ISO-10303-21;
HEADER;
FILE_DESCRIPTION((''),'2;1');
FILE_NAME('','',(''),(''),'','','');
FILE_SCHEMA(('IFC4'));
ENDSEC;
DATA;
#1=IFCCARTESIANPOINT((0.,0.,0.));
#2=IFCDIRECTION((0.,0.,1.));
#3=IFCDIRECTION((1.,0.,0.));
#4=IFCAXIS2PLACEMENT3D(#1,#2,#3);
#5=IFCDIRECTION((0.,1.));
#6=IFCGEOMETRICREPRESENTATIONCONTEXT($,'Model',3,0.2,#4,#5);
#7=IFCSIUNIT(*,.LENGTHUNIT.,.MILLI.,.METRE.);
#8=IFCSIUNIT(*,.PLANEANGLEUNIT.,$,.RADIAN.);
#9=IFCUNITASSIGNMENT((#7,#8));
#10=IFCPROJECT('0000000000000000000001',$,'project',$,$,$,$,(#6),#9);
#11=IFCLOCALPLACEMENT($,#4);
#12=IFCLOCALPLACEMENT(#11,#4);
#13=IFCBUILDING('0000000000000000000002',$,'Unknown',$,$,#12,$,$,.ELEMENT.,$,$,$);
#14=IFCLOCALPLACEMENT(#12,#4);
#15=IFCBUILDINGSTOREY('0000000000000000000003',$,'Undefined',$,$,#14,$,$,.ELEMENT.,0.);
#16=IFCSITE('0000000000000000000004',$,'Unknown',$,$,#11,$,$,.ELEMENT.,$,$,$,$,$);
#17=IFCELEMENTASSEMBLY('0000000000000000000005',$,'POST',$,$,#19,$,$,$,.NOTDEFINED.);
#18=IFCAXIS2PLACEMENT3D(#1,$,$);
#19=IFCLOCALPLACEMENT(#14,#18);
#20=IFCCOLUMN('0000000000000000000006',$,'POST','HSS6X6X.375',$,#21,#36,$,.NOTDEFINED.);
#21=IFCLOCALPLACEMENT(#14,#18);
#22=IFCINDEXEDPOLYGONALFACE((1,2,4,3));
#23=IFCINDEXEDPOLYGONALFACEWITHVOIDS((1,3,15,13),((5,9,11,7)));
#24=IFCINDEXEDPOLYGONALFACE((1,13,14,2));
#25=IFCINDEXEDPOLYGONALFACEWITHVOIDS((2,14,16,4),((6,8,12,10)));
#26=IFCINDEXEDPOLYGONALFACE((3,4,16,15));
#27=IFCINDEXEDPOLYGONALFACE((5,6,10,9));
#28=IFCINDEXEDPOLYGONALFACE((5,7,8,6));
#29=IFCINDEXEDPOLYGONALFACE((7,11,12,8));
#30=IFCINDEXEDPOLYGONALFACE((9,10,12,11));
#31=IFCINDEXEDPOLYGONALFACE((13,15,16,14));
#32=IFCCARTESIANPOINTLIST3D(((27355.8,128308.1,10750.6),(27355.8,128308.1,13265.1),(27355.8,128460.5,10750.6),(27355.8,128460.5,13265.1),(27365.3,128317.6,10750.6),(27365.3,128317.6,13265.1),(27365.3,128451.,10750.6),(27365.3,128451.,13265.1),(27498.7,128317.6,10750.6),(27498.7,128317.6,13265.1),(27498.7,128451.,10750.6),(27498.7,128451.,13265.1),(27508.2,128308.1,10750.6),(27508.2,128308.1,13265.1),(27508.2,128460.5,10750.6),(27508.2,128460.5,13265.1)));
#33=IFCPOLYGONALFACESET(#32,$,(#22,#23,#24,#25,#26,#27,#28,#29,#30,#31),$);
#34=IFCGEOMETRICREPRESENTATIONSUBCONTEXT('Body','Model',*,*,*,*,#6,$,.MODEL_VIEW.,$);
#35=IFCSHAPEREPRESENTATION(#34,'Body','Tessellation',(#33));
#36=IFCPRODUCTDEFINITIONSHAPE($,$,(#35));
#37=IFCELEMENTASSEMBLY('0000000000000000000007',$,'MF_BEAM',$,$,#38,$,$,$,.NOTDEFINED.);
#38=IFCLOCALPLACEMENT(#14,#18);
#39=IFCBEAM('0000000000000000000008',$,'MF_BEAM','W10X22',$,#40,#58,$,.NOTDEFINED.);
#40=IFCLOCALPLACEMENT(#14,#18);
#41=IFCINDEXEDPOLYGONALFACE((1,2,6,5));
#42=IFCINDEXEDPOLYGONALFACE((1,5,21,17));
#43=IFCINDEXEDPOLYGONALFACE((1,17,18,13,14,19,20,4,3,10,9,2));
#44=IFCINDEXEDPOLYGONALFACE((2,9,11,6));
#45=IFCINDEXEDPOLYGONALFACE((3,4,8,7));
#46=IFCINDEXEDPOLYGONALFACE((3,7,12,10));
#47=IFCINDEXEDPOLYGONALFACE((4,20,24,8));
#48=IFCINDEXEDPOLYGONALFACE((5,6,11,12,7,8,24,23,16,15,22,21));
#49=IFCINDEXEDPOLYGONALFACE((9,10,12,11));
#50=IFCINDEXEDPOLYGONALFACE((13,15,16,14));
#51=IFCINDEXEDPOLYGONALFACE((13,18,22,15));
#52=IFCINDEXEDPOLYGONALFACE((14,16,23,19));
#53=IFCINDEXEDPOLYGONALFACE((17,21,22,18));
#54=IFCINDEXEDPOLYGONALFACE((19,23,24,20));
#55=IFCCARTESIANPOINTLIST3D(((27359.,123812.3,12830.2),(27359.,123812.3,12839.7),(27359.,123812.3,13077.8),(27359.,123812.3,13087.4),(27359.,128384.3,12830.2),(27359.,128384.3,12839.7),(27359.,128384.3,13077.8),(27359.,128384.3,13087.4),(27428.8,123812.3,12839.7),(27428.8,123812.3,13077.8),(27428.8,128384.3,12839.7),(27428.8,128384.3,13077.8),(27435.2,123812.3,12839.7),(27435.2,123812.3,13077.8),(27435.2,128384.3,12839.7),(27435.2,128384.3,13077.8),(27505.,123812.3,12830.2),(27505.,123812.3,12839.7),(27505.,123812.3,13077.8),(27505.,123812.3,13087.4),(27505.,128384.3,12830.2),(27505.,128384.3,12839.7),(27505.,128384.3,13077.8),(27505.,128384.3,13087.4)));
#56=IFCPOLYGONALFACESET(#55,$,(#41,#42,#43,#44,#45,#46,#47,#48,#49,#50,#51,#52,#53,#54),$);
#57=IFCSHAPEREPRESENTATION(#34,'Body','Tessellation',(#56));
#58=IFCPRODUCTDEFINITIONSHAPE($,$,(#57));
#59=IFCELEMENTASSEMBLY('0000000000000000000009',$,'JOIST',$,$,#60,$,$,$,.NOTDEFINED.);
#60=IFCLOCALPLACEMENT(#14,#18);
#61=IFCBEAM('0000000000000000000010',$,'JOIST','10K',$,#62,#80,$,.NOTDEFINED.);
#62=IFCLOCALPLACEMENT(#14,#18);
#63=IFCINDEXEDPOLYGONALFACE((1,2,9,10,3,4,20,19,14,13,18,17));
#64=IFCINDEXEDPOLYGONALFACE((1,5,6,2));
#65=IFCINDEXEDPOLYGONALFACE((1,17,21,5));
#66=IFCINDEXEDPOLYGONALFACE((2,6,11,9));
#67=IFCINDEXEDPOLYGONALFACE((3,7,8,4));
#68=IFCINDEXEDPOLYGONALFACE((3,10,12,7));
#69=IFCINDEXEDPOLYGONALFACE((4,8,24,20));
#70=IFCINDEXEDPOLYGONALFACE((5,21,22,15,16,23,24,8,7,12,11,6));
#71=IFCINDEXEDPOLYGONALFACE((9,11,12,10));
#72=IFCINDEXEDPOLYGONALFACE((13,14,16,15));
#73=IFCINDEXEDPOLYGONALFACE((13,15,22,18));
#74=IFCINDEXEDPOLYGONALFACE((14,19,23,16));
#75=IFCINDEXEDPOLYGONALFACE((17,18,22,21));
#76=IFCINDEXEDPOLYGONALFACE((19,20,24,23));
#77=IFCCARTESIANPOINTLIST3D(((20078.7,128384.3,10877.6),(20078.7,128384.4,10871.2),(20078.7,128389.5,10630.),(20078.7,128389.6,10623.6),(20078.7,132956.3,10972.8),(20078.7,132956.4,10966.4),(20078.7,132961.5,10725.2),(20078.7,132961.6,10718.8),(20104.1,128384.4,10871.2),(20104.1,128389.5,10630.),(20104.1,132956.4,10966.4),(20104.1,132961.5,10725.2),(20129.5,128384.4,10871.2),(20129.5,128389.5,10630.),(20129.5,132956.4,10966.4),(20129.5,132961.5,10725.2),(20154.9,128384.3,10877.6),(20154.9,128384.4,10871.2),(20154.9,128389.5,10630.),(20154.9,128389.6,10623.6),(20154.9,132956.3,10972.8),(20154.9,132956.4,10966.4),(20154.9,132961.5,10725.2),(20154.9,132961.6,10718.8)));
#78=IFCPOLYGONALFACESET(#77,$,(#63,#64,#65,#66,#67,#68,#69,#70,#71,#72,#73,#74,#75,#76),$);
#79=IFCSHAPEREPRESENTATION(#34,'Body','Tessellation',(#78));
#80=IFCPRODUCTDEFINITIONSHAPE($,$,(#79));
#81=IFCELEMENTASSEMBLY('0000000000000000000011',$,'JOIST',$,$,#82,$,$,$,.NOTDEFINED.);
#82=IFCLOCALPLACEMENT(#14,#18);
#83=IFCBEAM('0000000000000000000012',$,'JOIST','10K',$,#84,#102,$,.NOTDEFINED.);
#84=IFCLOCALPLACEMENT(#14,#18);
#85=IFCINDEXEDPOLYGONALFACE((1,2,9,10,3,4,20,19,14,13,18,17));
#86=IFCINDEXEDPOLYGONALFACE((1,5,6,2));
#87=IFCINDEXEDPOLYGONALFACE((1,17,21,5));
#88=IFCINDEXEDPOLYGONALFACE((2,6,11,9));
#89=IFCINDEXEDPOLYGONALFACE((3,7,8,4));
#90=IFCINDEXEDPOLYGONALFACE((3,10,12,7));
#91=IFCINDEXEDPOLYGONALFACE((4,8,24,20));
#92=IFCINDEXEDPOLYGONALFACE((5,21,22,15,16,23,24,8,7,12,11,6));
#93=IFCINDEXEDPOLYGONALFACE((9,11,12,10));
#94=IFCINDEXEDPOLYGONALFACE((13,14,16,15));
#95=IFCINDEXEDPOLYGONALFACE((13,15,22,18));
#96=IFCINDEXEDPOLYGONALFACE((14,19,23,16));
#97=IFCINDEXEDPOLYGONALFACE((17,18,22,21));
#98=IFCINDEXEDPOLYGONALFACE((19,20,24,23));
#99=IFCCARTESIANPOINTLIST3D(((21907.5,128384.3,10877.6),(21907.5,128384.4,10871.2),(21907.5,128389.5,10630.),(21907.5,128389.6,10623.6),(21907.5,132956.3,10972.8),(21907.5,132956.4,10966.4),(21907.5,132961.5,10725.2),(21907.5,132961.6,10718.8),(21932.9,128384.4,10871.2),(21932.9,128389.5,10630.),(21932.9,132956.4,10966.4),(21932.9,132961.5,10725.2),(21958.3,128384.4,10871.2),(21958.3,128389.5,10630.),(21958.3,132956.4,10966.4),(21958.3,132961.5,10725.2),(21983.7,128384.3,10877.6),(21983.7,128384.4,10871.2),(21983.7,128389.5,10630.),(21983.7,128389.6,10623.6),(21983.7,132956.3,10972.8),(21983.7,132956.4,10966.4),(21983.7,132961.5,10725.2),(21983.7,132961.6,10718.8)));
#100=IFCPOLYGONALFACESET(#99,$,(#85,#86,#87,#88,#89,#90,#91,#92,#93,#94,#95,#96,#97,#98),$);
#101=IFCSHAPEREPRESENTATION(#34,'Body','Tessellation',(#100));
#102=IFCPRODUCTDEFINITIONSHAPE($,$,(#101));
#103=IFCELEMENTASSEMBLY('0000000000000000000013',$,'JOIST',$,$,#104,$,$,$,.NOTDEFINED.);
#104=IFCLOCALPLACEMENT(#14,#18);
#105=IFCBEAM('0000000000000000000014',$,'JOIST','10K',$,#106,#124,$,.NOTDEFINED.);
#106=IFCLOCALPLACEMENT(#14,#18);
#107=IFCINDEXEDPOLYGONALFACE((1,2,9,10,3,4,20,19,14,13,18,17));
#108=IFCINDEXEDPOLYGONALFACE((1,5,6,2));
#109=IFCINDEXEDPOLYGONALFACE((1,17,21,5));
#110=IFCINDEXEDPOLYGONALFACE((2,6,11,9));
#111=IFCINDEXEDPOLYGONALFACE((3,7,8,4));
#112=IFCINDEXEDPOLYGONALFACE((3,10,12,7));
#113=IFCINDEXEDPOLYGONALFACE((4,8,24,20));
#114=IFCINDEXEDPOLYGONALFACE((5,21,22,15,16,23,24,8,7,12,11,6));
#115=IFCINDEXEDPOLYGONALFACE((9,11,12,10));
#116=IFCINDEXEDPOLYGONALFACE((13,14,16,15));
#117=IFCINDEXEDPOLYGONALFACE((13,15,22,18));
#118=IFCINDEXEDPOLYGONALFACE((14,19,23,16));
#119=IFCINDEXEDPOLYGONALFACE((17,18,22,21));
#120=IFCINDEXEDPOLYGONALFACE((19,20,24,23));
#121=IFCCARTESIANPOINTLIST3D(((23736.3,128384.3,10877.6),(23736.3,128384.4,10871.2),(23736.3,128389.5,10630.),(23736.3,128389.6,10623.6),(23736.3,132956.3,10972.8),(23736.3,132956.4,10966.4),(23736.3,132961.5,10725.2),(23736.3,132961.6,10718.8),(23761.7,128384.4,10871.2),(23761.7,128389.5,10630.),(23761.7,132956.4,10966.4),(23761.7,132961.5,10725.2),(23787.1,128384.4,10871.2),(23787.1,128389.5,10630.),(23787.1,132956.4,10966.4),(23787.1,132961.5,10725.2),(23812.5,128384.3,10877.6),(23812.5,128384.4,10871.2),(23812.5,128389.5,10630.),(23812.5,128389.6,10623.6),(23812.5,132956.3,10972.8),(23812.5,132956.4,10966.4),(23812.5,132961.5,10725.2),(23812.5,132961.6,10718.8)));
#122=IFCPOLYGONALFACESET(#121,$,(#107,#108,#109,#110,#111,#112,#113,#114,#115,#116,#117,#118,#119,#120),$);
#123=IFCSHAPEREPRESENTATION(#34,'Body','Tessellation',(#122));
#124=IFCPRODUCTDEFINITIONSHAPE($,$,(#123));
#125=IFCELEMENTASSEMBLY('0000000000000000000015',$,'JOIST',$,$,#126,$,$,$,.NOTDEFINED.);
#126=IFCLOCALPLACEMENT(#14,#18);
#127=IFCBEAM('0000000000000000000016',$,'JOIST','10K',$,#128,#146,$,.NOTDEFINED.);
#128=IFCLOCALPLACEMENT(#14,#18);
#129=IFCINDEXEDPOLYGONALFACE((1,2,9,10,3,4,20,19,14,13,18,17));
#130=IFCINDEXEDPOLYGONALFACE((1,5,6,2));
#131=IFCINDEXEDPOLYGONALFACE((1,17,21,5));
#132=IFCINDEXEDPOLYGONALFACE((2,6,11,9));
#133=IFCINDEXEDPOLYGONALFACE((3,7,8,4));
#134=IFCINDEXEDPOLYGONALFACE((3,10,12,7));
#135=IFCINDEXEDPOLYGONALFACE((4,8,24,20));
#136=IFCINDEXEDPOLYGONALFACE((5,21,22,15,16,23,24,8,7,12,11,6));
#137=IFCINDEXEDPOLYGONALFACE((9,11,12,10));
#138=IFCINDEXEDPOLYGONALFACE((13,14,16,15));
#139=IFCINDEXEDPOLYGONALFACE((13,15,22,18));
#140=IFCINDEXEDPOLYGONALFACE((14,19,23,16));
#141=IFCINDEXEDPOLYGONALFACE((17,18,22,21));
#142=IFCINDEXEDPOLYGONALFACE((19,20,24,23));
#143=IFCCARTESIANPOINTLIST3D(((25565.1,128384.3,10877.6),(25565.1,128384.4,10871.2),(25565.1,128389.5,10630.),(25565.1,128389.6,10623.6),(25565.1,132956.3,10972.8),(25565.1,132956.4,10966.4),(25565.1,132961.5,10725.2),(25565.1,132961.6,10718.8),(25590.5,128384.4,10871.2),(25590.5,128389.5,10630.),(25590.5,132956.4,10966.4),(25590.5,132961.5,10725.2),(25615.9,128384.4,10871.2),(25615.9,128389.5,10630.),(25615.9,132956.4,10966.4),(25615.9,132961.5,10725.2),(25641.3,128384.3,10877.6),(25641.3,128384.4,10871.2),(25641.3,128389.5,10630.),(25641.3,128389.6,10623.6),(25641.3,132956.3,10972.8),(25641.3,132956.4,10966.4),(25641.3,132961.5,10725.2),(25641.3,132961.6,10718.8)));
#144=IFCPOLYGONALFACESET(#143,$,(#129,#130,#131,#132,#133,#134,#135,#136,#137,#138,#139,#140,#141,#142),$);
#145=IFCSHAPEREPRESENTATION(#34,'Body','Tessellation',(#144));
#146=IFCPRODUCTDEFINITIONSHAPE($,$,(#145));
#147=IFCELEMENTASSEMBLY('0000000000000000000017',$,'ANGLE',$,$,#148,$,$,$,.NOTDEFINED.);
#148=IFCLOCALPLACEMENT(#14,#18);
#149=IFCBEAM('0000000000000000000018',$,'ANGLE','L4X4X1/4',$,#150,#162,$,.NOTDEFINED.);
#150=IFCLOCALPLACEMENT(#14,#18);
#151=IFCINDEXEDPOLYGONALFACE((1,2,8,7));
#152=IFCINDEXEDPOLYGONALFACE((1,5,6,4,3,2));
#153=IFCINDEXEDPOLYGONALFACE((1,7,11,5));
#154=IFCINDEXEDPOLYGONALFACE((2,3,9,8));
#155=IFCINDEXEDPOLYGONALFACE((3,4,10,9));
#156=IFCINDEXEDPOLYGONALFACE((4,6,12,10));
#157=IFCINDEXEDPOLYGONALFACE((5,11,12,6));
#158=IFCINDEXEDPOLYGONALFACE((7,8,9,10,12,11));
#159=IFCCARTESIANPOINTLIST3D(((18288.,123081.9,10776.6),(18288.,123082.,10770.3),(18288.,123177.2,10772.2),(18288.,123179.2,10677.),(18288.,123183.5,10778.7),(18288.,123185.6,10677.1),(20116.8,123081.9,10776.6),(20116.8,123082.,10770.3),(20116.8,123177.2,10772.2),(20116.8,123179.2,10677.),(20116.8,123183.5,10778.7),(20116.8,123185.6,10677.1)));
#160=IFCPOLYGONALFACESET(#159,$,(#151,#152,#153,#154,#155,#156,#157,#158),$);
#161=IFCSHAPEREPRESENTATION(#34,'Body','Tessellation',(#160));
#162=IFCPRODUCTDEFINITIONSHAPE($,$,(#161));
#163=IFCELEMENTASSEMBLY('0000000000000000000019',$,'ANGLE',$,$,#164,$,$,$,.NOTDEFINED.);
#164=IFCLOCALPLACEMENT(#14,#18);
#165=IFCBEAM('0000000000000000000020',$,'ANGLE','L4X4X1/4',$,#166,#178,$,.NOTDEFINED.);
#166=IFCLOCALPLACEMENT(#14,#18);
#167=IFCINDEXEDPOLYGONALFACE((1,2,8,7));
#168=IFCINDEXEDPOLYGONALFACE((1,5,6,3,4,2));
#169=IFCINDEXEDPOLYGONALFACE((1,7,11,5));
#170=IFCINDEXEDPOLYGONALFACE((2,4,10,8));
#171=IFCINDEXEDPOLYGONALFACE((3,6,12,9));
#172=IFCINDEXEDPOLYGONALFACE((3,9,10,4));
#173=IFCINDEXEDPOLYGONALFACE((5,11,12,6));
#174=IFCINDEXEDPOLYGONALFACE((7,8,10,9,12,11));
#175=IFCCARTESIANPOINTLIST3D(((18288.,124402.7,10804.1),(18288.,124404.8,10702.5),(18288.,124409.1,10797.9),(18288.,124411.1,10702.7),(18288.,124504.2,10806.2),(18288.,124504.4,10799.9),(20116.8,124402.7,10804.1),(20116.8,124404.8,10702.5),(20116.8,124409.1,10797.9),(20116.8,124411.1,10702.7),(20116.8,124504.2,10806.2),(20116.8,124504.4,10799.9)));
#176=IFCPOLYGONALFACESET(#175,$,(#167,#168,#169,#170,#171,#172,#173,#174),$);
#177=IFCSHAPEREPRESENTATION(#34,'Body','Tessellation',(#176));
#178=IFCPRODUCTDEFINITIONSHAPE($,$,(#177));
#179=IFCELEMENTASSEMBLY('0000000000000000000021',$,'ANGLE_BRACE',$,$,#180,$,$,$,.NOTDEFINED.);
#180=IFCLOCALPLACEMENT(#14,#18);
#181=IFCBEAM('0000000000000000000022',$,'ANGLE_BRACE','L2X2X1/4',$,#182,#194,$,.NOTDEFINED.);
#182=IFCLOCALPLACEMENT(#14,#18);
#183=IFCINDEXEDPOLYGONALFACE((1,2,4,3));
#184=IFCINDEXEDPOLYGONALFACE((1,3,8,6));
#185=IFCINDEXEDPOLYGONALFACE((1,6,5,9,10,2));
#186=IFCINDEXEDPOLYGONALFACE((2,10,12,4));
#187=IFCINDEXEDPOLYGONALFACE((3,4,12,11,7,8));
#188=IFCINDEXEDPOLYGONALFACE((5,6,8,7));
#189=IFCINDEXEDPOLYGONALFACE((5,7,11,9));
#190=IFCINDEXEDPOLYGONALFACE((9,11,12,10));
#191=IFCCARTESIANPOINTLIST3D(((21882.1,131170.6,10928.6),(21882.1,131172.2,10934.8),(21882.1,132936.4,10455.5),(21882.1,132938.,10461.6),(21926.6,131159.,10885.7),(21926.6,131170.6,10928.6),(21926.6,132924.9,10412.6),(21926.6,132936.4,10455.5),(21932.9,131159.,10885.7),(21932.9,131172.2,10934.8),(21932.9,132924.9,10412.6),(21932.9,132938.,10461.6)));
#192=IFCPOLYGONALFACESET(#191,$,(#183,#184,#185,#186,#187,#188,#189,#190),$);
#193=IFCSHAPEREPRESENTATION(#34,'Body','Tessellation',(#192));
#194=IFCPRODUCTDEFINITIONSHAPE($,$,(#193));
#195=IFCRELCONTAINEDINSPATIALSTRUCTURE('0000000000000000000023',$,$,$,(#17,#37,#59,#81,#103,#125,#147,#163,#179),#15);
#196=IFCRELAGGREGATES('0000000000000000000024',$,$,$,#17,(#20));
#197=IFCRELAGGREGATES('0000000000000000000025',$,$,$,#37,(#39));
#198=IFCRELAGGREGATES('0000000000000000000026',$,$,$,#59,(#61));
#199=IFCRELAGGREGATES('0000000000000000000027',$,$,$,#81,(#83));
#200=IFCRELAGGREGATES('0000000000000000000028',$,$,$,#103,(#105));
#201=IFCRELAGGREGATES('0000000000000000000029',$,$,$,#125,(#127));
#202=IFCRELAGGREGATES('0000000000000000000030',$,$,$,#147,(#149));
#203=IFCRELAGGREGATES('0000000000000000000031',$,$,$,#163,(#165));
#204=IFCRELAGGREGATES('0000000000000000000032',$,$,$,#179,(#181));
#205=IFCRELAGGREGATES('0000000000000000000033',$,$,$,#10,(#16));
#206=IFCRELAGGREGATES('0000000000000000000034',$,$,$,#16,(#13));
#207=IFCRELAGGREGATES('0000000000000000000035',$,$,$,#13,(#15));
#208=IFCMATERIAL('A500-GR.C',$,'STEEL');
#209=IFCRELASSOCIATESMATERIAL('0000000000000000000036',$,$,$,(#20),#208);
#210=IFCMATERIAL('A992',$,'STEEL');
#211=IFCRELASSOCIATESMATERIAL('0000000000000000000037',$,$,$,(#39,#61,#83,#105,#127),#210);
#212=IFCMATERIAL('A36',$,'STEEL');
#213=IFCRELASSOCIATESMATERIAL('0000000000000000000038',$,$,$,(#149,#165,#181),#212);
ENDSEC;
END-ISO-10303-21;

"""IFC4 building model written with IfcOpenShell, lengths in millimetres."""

from ifc_helpers import new_model, si_unit, direction, frame, origin_with_axes, place, context, subcontext, project, spatial, line, indexed_curve, outline, extrude, material, element, aggregate, save


model = new_model("IFC4")

# Units and contexts
model_context = context("Model", 3, precision=0.2, world=origin_with_axes(), true_north=direction((0.0, 1.0)))
body_context = subcontext(model_context, "Body", "Model", "MODEL_VIEW")
ifc_project = project(units=[si_unit("LENGTHUNIT", "METRE", prefix="MILLI"), si_unit("PLANEANGLEUNIT", "RADIAN")], contexts=[model_context])

# Site, building, storey
site_placement = place(None, origin_with_axes())
site = spatial("IfcSite", under=ifc_project, at=site_placement, Name="Unknown", CompositionType="ELEMENT")
building_placement = place(site_placement, origin_with_axes())
building = spatial("IfcBuilding", under=site, at=building_placement, Name="Unknown", CompositionType="ELEMENT")
storey_placement = place(building_placement, origin_with_axes())
storey = spatial("IfcBuildingStorey", under=building, at=storey_placement, Name="Undefined", CompositionType="ELEMENT", Elevation=0.0)

# Element assembly, column
assembly_1_placement = place(storey_placement, frame((27432.0, 128384.3, 10750.5), z_axis=(0.0, -1.0, 0.0), x_axis=(0.0, 0.0, 1.0)))
assembly_1 = element("IfcElementAssembly", 1, at=assembly_1_placement, inside=storey, Name="POST", PredefinedType="NOTDEFINED")
ifc_material_1 = material(Name="A500-GR.C", Category="STEEL")
column_placement = place(assembly_1_placement, origin_with_axes())
column = element("IfcColumn", 2, at=column_placement, material=ifc_material_1, Name="POST", Description="HSS6X6X.375", PredefinedType="NOTDEFINED", context=body_context, shape_type="SolidModel", body=[
    extrude(outline(indexed_curve([(-76.2, -76.2), (76.2, -76.2), (76.2, 76.2), (-76.2, 76.2)], segments=[line(1, 2, 3, 4, 1)]), holes=[indexed_curve([(-66.7, -66.7), (-66.7, 66.7), (66.7, 66.7), (66.7, -66.7)], segments=[line(1, 2, 3, 4, 1)])]), frame((0.0, 0.0, 0.0), z_axis=(-1.0, 0.0, 0.0), x_axis=(0.0, 0.0, 1.0)), (0.0, 0.0, -1.0), 2514.6),
])
aggregate(assembly_1, [column])

# Element assemblies, beams
assembly_2_placement = place(storey_placement, frame((27432.0, 123812.3, 12958.8), z_axis=(1.0, 0.0, 0.0), x_axis=(0.0, 1.0, 0.0)))
assembly_2 = element("IfcElementAssembly", 3, at=assembly_2_placement, inside=storey, Name="MF_BEAM", PredefinedType="NOTDEFINED")
ifc_material_2 = material(Name="A992", Category="STEEL")
beam_1_placement = place(assembly_2_placement, origin_with_axes())
beam_1 = element("IfcBeam", 4, at=beam_1_placement, material=ifc_material_2, Name="MF_BEAM", Description="W10X22", PredefinedType="NOTDEFINED", context=body_context, shape_type="SolidModel", body=[
    extrude(outline(indexed_curve([(-73.0, -128.6), (73.0, -128.6), (73.0, -119.1), (3.2, -119.1), (3.2, 119.1), (73.0, 119.1), (73.0, 128.6), (-73.0, 128.6), (-73.0, 119.1), (-3.2, 119.1), (-3.2, -119.1), (-73.0, -119.1)], segments=[line(1, 2, 3, 4, 5, 6, 7, 8, 9, 10, 11, 12, 1)])), frame((0.0, 0.0, 0.0), z_axis=(-1.0, 0.0, 0.0), x_axis=(0.0, 0.0, 1.0)), (0.0, 0.0, -1.0), 4572.0),
])
aggregate(assembly_2, [beam_1])
assembly_3_placement = place(storey_placement, frame((20116.8, 128386.9, 10750.6), z_axis=(1.0, 0.0, 0.0), x_axis=(0.0, 0.999783, 0.020819)))
assembly_3 = element("IfcElementAssembly", 5, at=assembly_3_placement, inside=storey, Name="JOIST", PredefinedType="NOTDEFINED")
beam_2_placement = place(assembly_3_placement, origin_with_axes())
beam_2 = element("IfcBeam", 6, at=beam_2_placement, material=ifc_material_2, Name="JOIST", Description="10K", PredefinedType="NOTDEFINED", context=body_context, shape_type="SolidModel", body=[
    extrude(outline(indexed_curve([(-38.1, -127.0), (38.1, -127.0), (38.1, -120.7), (12.7, -120.7), (12.7, 120.7), (38.1, 120.7), (38.1, 127.0), (-38.1, 127.0), (-38.1, 120.7), (-12.7, 120.7), (-12.7, -120.7), (-38.1, -120.7)], segments=[line(1, 2, 3, 4, 5, 6, 7, 8, 9, 10, 11, 12, 1)])), frame((0.0, 0.0, 0.0), z_axis=(-1.0, 0.0, 0.0), x_axis=(0.0, 0.0, 1.0)), (0.0, 0.0, -1.0), 4573.0),
])
aggregate(assembly_3, [beam_2])
assembly_4_placement = place(storey_placement, frame((21945.6, 128386.9, 10750.6), z_axis=(1.0, 0.0, 0.0), x_axis=(0.0, 0.999783, 0.020819)))
assembly_4 = element("IfcElementAssembly", 7, at=assembly_4_placement, inside=storey, Name="JOIST", PredefinedType="NOTDEFINED")
beam_3_placement = place(assembly_4_placement, origin_with_axes())
beam_3 = element("IfcBeam", 8, at=beam_3_placement, material=ifc_material_2, Name="JOIST", Description="10K", PredefinedType="NOTDEFINED", context=body_context, shape_type="SolidModel", body=[
    extrude(outline(indexed_curve([(-38.1, -127.0), (38.1, -127.0), (38.1, -120.7), (12.7, -120.7), (12.7, 120.7), (38.1, 120.7), (38.1, 127.0), (-38.1, 127.0), (-38.1, 120.7), (-12.7, 120.7), (-12.7, -120.7), (-38.1, -120.7)], segments=[line(1, 2, 3, 4, 5, 6, 7, 8, 9, 10, 11, 12, 1)])), frame((0.0, 0.0, 0.0), z_axis=(-1.0, 0.0, 0.0), x_axis=(0.0, 0.0, 1.0)), (0.0, 0.0, -1.0), 4573.0),
])
aggregate(assembly_4, [beam_3])
assembly_5_placement = place(storey_placement, frame((23774.4, 128386.9, 10750.6), z_axis=(1.0, 0.0, 0.0), x_axis=(0.0, 0.999783, 0.020819)))
assembly_5 = element("IfcElementAssembly", 9, at=assembly_5_placement, inside=storey, Name="JOIST", PredefinedType="NOTDEFINED")
beam_4_placement = place(assembly_5_placement, origin_with_axes())
beam_4 = element("IfcBeam", 10, at=beam_4_placement, material=ifc_material_2, Name="JOIST", Description="10K", PredefinedType="NOTDEFINED", context=body_context, shape_type="SolidModel", body=[
    extrude(outline(indexed_curve([(-38.1, -127.0), (38.1, -127.0), (38.1, -120.7), (12.7, -120.7), (12.7, 120.7), (38.1, 120.7), (38.1, 127.0), (-38.1, 127.0), (-38.1, 120.7), (-12.7, 120.7), (-12.7, -120.7), (-38.1, -120.7)], segments=[line(1, 2, 3, 4, 5, 6, 7, 8, 9, 10, 11, 12, 1)])), frame((0.0, 0.0, 0.0), z_axis=(-1.0, 0.0, 0.0), x_axis=(0.0, 0.0, 1.0)), (0.0, 0.0, -1.0), 4573.0),
])
aggregate(assembly_5, [beam_4])
assembly_6_placement = place(storey_placement, frame((25603.2, 128386.9, 10750.6), z_axis=(1.0, 0.0, 0.0), x_axis=(0.0, 0.999783, 0.020819)))
assembly_6 = element("IfcElementAssembly", 11, at=assembly_6_placement, inside=storey, Name="JOIST", PredefinedType="NOTDEFINED")
beam_5_placement = place(assembly_6_placement, origin_with_axes())
beam_5 = element("IfcBeam", 12, at=beam_5_placement, material=ifc_material_2, Name="JOIST", Description="10K", PredefinedType="NOTDEFINED", context=body_context, shape_type="SolidModel", body=[
    extrude(outline(indexed_curve([(-38.1, -127.0), (38.1, -127.0), (38.1, -120.7), (12.7, -120.7), (12.7, 120.7), (38.1, 120.7), (38.1, 127.0), (-38.1, 127.0), (-38.1, 120.7), (-12.7, 120.7), (-12.7, -120.7), (-38.1, -120.7)], segments=[line(1, 2, 3, 4, 5, 6, 7, 8, 9, 10, 11, 12, 1)])), frame((0.0, 0.0, 0.0), z_axis=(-1.0, 0.0, 0.0), x_axis=(0.0, 0.0, 1.0)), (0.0, 0.0, -1.0), 4573.0),
])
aggregate(assembly_6, [beam_5])
assembly_7_placement = place(storey_placement, frame((18288.0, 123133.7, 10726.9), z_axis=(0.0, 0.020829, -0.999783), x_axis=(1.0, 0.0, 0.0)))
assembly_7 = element("IfcElementAssembly", 13, at=assembly_7_placement, inside=storey, Name="ANGLE", PredefinedType="NOTDEFINED")
ifc_material_3 = material(Name="A36", Category="STEEL")
beam_6_placement = place(assembly_7_placement, origin_with_axes())
beam_6 = element("IfcBeam", 14, at=beam_6_placement, material=ifc_material_3, Name="ANGLE", Description="L4X4X1/4", PredefinedType="NOTDEFINED", context=body_context, shape_type="SolidModel", body=[
    extrude(outline(indexed_curve([(-50.8, -50.8), (50.8, -50.8), (50.8, -44.5), (-44.5, -44.5), (-44.5, 50.8), (-50.8, 50.8)], segments=[line(1, 2, 3, 4, 5, 6, 1)])), frame((0.0, 0.0, 0.0), z_axis=(-1.0, 0.0, 0.0), x_axis=(0.0, 0.0, 1.0)), (0.0, 0.0, -1.0), 1828.8),
])
aggregate(assembly_7, [beam_6])
assembly_8_placement = place(storey_placement, frame((18288.0, 124454.5, 10754.4), z_axis=(0.0, 0.999783, 0.020819), x_axis=(1.0, 0.0, 0.0)))
assembly_8 = element("IfcElementAssembly", 15, at=assembly_8_placement, inside=storey, Name="ANGLE", PredefinedType="NOTDEFINED")
beam_7_placement = place(assembly_8_placement, origin_with_axes())
beam_7 = element("IfcBeam", 16, at=beam_7_placement, material=ifc_material_3, Name="ANGLE", Description="L4X4X1/4", PredefinedType="NOTDEFINED", context=body_context, shape_type="SolidModel", body=[
    extrude(outline(indexed_curve([(-50.8, -50.8), (50.8, -50.8), (50.8, -44.5), (-44.5, -44.5), (-44.5, 50.8), (-50.8, 50.8)], segments=[line(1, 2, 3, 4, 5, 6, 1)])), frame((0.0, 0.0, 0.0), z_axis=(-1.0, 0.0, 0.0), x_axis=(0.0, 0.0, 1.0)), (0.0, 0.0, -1.0), 1828.8),
])
aggregate(assembly_8, [beam_7])
assembly_9_placement = place(storey_placement, frame((21907.5, 131165.6, 10910.2), z_axis=(-1.0, 0.0, 0.0), x_axis=(0.0, 0.965926, -0.258819)))
assembly_9 = element("IfcElementAssembly", 17, at=assembly_9_placement, inside=storey, Name="ANGLE_BRACE", PredefinedType="NOTDEFINED")
beam_8_placement = place(assembly_9_placement, origin_with_axes())
beam_8 = element("IfcBeam", 18, at=beam_8_placement, material=ifc_material_3, Name="ANGLE_BRACE", Description="L2X2X1/4", PredefinedType="NOTDEFINED", context=body_context, shape_type="SolidModel", body=[
    extrude(outline(indexed_curve([(-25.4, -25.4), (25.4, -25.4), (25.4, -19.1), (-19.1, -19.1), (-19.1, 25.4), (-25.4, 25.4)], segments=[line(1, 2, 3, 4, 5, 6, 1)])), frame((0.0, 0.0, 0.0), z_axis=(-1.0, 0.0, 0.0), x_axis=(0.0, 0.0, 1.0)), (0.0, 0.0, -1.0), 1828.1),
])
aggregate(assembly_9, [beam_8])

save(model, "model.ifc")
